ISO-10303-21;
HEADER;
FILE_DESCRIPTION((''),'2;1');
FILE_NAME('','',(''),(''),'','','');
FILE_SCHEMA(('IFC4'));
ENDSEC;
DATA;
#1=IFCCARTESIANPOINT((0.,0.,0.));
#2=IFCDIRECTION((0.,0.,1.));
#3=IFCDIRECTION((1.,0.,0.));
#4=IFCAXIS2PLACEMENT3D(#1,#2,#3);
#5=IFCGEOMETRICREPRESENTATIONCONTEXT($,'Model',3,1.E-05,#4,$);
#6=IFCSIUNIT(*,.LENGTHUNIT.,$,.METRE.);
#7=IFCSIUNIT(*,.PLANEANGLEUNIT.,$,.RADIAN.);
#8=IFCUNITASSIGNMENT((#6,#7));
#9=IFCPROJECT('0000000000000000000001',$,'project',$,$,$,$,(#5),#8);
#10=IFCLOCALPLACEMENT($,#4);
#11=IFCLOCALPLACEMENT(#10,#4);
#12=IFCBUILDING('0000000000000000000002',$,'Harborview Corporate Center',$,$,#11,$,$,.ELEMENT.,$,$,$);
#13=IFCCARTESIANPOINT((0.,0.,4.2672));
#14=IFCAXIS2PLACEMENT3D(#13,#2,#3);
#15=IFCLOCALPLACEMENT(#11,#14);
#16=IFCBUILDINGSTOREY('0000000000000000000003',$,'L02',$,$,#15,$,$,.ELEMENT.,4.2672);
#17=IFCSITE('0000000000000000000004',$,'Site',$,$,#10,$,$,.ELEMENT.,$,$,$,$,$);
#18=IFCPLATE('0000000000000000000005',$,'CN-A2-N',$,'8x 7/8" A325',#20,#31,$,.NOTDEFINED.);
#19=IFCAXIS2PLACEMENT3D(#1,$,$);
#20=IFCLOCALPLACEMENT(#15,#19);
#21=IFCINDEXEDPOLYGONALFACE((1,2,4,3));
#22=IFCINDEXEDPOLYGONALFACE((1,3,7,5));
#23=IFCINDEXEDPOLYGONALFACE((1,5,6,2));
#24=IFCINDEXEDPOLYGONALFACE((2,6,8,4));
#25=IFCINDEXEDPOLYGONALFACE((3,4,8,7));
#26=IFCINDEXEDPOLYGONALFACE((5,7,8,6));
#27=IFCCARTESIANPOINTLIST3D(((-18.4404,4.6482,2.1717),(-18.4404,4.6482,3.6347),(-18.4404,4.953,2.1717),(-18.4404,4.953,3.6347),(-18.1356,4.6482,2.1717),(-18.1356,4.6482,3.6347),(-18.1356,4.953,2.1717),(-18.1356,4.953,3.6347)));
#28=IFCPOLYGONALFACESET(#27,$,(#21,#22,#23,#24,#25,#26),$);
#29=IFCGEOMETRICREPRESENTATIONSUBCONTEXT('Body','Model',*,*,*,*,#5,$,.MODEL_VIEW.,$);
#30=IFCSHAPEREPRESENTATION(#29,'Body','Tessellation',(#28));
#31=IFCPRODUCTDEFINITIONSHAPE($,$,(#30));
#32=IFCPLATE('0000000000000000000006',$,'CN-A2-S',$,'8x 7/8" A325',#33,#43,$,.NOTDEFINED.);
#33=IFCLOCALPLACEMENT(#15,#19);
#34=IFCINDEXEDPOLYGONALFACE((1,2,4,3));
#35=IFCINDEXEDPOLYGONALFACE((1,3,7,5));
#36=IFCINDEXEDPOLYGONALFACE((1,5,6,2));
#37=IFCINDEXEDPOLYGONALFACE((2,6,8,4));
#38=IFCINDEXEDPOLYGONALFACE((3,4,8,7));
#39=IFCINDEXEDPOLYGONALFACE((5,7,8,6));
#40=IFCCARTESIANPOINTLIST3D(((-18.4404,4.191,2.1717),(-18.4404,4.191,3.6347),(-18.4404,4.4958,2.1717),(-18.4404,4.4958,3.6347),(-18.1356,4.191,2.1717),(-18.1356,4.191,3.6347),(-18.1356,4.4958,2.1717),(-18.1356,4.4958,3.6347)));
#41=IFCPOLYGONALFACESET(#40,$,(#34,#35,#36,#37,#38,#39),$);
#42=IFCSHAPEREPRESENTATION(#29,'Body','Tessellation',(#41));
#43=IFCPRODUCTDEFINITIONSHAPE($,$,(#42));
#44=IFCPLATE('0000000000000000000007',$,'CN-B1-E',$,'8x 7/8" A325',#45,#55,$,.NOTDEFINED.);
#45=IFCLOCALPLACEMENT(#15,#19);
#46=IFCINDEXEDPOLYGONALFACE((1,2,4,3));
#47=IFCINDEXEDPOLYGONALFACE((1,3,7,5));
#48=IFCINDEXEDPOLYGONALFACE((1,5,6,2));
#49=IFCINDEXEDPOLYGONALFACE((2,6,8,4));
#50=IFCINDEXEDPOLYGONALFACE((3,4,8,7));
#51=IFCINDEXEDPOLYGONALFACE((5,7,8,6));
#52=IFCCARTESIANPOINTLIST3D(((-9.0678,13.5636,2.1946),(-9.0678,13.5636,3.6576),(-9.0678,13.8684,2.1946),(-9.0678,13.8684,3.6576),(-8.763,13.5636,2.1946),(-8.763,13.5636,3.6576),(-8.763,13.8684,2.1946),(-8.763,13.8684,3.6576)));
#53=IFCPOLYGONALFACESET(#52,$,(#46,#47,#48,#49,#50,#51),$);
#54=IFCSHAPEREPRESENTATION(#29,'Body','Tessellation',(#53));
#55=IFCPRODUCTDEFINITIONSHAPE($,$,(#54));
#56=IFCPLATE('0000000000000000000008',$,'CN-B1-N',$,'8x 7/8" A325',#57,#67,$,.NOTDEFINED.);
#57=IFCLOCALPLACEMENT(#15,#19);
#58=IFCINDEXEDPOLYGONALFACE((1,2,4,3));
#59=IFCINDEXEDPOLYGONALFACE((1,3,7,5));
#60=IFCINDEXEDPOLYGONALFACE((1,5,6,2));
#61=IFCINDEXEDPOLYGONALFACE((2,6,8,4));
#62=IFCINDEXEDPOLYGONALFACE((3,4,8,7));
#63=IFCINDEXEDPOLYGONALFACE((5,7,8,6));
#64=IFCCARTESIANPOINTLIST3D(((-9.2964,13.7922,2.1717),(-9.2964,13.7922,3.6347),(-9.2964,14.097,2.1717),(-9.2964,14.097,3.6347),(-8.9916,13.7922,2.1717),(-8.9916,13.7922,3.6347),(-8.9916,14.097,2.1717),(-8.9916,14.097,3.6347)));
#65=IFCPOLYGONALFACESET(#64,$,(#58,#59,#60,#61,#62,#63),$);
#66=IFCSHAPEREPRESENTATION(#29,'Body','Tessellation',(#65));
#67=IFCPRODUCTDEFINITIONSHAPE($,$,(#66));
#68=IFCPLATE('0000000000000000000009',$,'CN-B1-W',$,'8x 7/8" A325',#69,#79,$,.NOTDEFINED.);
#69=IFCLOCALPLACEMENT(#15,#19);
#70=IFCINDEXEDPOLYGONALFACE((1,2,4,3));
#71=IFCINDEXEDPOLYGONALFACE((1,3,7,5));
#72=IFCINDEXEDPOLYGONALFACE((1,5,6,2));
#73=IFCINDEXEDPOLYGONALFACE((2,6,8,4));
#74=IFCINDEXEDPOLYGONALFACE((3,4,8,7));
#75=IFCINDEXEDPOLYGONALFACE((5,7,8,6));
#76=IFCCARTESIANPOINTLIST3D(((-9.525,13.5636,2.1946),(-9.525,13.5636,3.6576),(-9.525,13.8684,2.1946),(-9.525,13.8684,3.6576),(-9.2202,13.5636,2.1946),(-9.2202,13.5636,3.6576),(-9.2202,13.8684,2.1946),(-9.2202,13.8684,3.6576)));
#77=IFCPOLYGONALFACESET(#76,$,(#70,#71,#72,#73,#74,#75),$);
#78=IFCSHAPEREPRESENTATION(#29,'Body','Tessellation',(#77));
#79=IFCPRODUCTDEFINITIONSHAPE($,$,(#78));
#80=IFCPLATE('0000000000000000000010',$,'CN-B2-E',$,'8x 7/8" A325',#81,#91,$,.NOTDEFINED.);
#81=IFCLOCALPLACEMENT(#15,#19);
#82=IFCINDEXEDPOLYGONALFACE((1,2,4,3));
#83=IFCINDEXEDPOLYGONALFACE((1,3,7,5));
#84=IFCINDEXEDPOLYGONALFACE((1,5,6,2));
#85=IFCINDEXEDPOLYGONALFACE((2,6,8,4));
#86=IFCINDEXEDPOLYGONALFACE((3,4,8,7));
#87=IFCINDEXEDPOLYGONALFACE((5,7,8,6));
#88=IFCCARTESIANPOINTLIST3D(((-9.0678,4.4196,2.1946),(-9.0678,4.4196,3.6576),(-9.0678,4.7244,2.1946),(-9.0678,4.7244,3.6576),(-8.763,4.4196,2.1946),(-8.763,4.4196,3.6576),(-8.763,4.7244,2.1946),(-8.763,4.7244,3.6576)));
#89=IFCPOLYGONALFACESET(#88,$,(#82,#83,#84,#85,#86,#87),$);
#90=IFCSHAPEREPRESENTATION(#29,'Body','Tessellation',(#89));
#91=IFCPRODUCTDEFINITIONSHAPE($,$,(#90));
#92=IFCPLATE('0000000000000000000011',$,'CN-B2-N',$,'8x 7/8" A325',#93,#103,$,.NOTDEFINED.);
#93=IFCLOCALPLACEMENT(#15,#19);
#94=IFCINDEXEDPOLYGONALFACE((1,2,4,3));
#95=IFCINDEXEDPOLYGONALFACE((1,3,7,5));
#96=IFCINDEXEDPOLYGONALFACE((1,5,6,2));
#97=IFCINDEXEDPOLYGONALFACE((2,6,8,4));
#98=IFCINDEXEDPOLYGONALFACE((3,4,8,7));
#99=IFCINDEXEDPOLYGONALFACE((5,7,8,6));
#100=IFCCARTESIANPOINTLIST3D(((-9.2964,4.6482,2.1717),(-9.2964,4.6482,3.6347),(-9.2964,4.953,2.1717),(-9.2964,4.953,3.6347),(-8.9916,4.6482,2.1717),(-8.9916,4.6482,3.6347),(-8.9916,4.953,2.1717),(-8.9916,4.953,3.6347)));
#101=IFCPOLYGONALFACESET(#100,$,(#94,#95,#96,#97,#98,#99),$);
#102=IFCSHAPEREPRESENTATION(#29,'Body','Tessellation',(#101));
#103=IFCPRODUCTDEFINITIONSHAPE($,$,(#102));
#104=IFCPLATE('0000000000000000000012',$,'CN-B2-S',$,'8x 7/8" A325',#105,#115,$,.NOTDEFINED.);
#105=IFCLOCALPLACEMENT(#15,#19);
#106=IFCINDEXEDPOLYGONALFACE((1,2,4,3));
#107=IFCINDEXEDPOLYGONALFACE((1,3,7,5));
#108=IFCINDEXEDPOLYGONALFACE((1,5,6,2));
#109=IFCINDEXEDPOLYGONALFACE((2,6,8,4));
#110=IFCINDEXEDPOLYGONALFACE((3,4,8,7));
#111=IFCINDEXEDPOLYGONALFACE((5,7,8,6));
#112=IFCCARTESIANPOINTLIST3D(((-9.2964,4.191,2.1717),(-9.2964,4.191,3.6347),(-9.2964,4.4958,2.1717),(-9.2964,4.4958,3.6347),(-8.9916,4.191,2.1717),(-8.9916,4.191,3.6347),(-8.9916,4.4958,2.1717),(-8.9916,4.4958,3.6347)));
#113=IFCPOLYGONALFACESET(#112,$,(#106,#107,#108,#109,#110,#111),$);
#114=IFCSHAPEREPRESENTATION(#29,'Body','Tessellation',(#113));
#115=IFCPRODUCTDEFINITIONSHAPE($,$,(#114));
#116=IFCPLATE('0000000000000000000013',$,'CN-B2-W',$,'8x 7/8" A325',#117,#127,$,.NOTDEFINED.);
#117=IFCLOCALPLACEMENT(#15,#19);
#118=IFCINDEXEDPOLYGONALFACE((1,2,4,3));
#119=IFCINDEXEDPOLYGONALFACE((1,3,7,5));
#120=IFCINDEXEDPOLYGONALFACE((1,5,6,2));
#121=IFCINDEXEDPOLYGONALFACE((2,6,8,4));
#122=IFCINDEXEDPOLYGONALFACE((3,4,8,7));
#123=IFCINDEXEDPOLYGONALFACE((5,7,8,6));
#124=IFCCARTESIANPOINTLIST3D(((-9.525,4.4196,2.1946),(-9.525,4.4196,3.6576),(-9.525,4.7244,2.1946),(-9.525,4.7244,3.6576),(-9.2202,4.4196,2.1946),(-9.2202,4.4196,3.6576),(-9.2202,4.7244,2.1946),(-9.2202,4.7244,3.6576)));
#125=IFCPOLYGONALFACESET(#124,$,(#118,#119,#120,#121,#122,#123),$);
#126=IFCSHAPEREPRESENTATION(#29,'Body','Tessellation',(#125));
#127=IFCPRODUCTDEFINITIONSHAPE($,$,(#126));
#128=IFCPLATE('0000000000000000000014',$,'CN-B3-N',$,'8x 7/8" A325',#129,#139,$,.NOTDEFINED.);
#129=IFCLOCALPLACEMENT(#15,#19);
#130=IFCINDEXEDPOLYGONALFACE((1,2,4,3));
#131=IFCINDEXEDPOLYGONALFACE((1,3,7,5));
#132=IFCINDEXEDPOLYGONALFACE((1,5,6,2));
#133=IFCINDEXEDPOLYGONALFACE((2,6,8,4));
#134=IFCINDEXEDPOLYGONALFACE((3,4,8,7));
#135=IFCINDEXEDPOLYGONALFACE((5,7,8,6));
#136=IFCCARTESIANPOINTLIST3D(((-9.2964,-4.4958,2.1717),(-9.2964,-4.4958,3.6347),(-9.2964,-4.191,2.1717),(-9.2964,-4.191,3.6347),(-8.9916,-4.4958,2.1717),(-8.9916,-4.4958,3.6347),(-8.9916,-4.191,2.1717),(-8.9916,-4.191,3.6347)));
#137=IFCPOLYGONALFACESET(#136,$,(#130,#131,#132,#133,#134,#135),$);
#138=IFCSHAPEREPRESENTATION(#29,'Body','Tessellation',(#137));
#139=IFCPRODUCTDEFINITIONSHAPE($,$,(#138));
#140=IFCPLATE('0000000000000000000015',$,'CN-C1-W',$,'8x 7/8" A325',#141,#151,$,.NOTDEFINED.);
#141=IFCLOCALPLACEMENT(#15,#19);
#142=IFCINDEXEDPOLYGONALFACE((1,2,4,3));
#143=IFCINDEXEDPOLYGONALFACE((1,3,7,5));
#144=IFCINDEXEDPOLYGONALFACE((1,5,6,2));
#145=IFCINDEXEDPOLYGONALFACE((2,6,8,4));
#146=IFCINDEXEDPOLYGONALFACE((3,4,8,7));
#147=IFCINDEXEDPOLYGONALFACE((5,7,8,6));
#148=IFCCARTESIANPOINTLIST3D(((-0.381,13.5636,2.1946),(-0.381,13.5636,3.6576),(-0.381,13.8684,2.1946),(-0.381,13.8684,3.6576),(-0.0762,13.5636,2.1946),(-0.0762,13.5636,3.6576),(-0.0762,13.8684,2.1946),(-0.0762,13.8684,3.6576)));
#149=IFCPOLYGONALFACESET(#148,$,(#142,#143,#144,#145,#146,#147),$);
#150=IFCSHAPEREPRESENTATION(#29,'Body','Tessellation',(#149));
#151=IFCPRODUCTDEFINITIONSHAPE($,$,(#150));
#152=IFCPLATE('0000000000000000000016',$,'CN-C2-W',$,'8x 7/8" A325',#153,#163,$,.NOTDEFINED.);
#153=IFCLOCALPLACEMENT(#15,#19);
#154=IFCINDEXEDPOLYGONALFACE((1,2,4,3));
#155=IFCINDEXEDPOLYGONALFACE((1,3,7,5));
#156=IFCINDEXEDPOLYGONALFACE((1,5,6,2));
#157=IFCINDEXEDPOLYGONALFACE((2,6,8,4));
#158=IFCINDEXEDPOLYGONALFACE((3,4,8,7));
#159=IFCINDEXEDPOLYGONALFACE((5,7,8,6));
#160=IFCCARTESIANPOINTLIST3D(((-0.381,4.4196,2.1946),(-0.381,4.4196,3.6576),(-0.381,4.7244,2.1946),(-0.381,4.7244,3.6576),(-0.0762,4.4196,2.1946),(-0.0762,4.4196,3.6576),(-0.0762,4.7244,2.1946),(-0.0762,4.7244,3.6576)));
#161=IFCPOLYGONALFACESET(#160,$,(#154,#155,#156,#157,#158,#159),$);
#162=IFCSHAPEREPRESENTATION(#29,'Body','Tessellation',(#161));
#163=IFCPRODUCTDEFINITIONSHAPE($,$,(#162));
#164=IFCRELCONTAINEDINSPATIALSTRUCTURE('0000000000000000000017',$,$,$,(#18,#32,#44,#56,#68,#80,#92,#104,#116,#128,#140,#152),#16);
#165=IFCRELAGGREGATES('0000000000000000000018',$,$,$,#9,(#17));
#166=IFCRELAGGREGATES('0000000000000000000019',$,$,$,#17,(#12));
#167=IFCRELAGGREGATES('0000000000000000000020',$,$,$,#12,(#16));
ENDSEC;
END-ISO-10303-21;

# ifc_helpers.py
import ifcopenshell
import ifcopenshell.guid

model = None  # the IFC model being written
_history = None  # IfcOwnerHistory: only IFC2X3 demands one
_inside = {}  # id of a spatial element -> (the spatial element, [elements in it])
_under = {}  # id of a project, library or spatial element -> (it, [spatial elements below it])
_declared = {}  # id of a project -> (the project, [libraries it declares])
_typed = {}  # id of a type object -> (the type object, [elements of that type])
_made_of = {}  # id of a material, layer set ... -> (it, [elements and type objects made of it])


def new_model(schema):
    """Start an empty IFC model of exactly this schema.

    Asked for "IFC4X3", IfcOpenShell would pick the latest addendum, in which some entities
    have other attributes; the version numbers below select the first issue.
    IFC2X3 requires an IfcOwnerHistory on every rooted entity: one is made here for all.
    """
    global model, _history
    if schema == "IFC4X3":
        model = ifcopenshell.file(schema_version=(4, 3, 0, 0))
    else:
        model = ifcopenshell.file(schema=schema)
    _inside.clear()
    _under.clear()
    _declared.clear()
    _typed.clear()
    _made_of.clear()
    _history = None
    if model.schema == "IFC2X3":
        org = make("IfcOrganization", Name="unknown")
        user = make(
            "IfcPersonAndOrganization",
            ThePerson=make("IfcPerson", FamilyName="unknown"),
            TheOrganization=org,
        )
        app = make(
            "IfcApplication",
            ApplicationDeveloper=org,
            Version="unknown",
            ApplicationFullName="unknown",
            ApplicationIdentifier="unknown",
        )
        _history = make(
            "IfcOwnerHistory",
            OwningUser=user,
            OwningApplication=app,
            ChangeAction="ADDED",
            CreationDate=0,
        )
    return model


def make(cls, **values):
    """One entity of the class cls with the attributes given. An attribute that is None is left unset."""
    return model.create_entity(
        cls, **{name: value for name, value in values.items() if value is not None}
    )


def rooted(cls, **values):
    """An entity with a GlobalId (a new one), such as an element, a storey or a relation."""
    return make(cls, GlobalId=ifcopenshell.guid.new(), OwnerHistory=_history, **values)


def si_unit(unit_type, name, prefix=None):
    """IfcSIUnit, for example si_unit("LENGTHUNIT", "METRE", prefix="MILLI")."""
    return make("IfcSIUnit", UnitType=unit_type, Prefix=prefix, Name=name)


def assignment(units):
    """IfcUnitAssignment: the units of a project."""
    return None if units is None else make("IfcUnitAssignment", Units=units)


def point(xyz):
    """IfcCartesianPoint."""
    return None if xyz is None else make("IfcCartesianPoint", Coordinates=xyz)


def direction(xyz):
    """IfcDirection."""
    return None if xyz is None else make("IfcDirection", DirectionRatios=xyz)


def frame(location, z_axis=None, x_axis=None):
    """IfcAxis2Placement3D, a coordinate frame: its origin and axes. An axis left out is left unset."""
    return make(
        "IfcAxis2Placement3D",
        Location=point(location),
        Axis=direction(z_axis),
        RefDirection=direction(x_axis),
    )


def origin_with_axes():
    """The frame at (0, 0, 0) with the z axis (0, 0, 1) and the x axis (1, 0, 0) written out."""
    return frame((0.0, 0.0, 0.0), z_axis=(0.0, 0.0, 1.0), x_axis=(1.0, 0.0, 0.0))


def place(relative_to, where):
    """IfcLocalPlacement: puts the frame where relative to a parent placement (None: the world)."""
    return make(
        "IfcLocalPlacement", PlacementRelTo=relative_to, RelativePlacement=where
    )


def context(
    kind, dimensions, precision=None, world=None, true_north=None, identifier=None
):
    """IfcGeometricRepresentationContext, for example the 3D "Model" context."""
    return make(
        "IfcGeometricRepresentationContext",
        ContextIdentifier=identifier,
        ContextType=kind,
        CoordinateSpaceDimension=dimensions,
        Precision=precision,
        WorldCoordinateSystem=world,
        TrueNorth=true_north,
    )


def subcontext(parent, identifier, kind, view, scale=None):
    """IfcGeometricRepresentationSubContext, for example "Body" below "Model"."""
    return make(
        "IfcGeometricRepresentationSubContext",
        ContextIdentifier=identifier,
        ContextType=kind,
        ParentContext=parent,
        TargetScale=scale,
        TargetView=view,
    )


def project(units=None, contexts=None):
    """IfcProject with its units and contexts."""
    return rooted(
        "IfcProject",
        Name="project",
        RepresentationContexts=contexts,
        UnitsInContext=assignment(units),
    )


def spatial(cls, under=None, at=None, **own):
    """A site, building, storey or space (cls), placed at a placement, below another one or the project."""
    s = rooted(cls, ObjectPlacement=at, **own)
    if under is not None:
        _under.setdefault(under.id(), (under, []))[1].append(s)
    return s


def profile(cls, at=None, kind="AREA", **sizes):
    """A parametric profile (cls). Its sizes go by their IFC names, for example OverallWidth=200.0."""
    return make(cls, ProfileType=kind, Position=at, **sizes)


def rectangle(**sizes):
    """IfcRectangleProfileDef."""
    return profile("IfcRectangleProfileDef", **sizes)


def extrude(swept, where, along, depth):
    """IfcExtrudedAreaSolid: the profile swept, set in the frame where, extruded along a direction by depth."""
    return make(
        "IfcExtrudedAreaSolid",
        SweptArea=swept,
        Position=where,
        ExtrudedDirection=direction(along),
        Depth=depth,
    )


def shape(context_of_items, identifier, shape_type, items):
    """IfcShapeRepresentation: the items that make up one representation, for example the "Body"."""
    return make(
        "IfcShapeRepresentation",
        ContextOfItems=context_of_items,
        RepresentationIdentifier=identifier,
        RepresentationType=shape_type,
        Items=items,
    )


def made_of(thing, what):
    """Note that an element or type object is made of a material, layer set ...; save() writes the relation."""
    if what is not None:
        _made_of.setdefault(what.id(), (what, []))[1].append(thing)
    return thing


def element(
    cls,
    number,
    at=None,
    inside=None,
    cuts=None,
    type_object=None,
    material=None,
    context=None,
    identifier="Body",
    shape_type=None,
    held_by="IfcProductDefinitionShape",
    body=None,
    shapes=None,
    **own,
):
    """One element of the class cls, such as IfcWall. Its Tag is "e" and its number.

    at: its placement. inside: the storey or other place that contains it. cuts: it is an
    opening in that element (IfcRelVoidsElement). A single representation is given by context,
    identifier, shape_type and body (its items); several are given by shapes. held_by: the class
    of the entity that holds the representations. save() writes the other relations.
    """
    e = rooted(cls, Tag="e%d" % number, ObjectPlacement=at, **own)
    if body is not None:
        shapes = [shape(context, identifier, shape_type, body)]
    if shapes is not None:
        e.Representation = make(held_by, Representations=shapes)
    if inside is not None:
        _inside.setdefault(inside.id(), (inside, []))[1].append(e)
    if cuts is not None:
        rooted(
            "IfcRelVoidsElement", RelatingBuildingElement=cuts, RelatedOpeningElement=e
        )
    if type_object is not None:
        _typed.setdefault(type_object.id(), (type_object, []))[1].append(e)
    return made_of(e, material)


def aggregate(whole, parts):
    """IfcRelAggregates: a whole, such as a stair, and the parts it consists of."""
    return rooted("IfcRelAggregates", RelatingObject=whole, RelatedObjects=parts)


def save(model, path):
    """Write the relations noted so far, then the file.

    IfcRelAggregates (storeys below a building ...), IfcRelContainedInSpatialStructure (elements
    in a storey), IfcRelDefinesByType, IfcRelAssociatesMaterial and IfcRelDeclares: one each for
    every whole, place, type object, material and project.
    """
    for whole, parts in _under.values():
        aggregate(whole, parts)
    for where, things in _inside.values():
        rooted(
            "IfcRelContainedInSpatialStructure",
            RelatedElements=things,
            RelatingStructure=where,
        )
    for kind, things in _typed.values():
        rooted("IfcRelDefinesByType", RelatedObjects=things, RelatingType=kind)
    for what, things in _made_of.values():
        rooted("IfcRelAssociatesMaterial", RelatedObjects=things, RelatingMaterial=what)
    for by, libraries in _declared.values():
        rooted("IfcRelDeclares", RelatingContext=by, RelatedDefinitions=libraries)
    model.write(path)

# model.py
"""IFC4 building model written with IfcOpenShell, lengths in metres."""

from ifc_helpers import new_model, si_unit, frame, origin_with_axes, place, context, subcontext, project, spatial, rectangle, extrude, element, save


model = new_model("IFC4")

# Units and contexts
model_context = context("Model", 3, precision=1e-05, world=origin_with_axes())
body_context = subcontext(model_context, "Body", "Model", "MODEL_VIEW")
ifc_project = project(units=[si_unit("LENGTHUNIT", "METRE"), si_unit("PLANEANGLEUNIT", "RADIAN")], contexts=[model_context])

# Site, building, storey
site_placement = place(None, origin_with_axes())
site = spatial("IfcSite", under=ifc_project, at=site_placement, Name="Site", CompositionType="ELEMENT")
building_placement = place(site_placement, origin_with_axes())
building = spatial("IfcBuilding", under=site, at=building_placement, Name="Harborview Corporate Center", CompositionType="ELEMENT")
storey_placement = place(building_placement, frame((0.0, 0.0, 4.2672), z_axis=(0.0, 0.0, 1.0), x_axis=(1.0, 0.0, 0.0)))
storey = spatial("IfcBuildingStorey", under=building, at=storey_placement, Name="L02", CompositionType="ELEMENT", Elevation=4.2672)

# Plates
for number, where, z_axis, x_axis, name in (
    (1, (-18.288, 4.8006, 2.1717), (0.0, 0.0, 1.0), (1.0, 0.0, 0.0), "CN-A2-N"),
    (2, (-18.288, 4.3434, 2.1717), (0.0, 0.0, 1.0), (1.0, 0.0, 0.0), "CN-A2-S"),
    (3, (-8.9154, 13.716, 2.1946), (0.0, 0.0, 1.0), (1.0, 0.0, 0.0), "CN-B1-E"),
    (4, (-9.144, 13.9446, 2.1717), (0.0, 0.0, 1.0), (1.0, 0.0, 0.0), "CN-B1-N"),
    (5, (-9.3726, 13.716, 2.1946), (0.0, 0.0, 1.0), (1.0, 0.0, 0.0), "CN-B1-W"),
    (6, (-8.9154, 4.572, 2.1946), (0.0, 0.0, 1.0), (1.0, 0.0, 0.0), "CN-B2-E"),
    (7, (-9.144, 4.8006, 2.1717), (0.0, 0.0, 1.0), (1.0, 0.0, 0.0), "CN-B2-N"),
    (8, (-9.144, 4.3434, 2.1717), (0.0, 0.0, 1.0), (1.0, 0.0, 0.0), "CN-B2-S"),
    (9, (-9.3726, 4.572, 2.1946), (0.0, 0.0, 1.0), (1.0, 0.0, 0.0), "CN-B2-W"),
    (10, (-9.144, -4.3434, 2.1717), (0.0, 0.0, 1.0), (1.0, 0.0, 0.0), "CN-B3-N"),
):
    element("IfcPlate", number, at=place(storey_placement, frame(where, z_axis=z_axis, x_axis=x_axis)), inside=storey, Name=name, ObjectType="8x 7/8\" A325", PredefinedType="NOTDEFINED", context=body_context, shape_type="SweptSolid", body=[
        extrude(rectangle(XDim=0.3048, YDim=0.3048), origin_with_axes(), (0.0, 0.0, 1.0), 1.463),
    ])
for number, where, z_axis, x_axis, name in (
    (11, (-0.2286, 13.716, 2.1946), (0.0, 0.0, 1.0), (1.0, 0.0, 0.0), "CN-C1-W"),
    (12, (-0.2286, 4.572, 2.1946), (0.0, 0.0, 1.0), (1.0, 0.0, 0.0), "CN-C2-W"),
):
    element("IfcPlate", number, at=place(storey_placement, frame(where, z_axis=z_axis, x_axis=x_axis)), inside=storey, Name=name, ObjectType="8x 7/8\" A325", PredefinedType="NOTDEFINED", context=body_context, shape_type="SweptSolid", body=[
        extrude(rectangle(XDim=0.3048, YDim=0.3048), origin_with_axes(), (0.0, 0.0, 1.0), 1.463),
    ])

save(model, "model.ifc")
